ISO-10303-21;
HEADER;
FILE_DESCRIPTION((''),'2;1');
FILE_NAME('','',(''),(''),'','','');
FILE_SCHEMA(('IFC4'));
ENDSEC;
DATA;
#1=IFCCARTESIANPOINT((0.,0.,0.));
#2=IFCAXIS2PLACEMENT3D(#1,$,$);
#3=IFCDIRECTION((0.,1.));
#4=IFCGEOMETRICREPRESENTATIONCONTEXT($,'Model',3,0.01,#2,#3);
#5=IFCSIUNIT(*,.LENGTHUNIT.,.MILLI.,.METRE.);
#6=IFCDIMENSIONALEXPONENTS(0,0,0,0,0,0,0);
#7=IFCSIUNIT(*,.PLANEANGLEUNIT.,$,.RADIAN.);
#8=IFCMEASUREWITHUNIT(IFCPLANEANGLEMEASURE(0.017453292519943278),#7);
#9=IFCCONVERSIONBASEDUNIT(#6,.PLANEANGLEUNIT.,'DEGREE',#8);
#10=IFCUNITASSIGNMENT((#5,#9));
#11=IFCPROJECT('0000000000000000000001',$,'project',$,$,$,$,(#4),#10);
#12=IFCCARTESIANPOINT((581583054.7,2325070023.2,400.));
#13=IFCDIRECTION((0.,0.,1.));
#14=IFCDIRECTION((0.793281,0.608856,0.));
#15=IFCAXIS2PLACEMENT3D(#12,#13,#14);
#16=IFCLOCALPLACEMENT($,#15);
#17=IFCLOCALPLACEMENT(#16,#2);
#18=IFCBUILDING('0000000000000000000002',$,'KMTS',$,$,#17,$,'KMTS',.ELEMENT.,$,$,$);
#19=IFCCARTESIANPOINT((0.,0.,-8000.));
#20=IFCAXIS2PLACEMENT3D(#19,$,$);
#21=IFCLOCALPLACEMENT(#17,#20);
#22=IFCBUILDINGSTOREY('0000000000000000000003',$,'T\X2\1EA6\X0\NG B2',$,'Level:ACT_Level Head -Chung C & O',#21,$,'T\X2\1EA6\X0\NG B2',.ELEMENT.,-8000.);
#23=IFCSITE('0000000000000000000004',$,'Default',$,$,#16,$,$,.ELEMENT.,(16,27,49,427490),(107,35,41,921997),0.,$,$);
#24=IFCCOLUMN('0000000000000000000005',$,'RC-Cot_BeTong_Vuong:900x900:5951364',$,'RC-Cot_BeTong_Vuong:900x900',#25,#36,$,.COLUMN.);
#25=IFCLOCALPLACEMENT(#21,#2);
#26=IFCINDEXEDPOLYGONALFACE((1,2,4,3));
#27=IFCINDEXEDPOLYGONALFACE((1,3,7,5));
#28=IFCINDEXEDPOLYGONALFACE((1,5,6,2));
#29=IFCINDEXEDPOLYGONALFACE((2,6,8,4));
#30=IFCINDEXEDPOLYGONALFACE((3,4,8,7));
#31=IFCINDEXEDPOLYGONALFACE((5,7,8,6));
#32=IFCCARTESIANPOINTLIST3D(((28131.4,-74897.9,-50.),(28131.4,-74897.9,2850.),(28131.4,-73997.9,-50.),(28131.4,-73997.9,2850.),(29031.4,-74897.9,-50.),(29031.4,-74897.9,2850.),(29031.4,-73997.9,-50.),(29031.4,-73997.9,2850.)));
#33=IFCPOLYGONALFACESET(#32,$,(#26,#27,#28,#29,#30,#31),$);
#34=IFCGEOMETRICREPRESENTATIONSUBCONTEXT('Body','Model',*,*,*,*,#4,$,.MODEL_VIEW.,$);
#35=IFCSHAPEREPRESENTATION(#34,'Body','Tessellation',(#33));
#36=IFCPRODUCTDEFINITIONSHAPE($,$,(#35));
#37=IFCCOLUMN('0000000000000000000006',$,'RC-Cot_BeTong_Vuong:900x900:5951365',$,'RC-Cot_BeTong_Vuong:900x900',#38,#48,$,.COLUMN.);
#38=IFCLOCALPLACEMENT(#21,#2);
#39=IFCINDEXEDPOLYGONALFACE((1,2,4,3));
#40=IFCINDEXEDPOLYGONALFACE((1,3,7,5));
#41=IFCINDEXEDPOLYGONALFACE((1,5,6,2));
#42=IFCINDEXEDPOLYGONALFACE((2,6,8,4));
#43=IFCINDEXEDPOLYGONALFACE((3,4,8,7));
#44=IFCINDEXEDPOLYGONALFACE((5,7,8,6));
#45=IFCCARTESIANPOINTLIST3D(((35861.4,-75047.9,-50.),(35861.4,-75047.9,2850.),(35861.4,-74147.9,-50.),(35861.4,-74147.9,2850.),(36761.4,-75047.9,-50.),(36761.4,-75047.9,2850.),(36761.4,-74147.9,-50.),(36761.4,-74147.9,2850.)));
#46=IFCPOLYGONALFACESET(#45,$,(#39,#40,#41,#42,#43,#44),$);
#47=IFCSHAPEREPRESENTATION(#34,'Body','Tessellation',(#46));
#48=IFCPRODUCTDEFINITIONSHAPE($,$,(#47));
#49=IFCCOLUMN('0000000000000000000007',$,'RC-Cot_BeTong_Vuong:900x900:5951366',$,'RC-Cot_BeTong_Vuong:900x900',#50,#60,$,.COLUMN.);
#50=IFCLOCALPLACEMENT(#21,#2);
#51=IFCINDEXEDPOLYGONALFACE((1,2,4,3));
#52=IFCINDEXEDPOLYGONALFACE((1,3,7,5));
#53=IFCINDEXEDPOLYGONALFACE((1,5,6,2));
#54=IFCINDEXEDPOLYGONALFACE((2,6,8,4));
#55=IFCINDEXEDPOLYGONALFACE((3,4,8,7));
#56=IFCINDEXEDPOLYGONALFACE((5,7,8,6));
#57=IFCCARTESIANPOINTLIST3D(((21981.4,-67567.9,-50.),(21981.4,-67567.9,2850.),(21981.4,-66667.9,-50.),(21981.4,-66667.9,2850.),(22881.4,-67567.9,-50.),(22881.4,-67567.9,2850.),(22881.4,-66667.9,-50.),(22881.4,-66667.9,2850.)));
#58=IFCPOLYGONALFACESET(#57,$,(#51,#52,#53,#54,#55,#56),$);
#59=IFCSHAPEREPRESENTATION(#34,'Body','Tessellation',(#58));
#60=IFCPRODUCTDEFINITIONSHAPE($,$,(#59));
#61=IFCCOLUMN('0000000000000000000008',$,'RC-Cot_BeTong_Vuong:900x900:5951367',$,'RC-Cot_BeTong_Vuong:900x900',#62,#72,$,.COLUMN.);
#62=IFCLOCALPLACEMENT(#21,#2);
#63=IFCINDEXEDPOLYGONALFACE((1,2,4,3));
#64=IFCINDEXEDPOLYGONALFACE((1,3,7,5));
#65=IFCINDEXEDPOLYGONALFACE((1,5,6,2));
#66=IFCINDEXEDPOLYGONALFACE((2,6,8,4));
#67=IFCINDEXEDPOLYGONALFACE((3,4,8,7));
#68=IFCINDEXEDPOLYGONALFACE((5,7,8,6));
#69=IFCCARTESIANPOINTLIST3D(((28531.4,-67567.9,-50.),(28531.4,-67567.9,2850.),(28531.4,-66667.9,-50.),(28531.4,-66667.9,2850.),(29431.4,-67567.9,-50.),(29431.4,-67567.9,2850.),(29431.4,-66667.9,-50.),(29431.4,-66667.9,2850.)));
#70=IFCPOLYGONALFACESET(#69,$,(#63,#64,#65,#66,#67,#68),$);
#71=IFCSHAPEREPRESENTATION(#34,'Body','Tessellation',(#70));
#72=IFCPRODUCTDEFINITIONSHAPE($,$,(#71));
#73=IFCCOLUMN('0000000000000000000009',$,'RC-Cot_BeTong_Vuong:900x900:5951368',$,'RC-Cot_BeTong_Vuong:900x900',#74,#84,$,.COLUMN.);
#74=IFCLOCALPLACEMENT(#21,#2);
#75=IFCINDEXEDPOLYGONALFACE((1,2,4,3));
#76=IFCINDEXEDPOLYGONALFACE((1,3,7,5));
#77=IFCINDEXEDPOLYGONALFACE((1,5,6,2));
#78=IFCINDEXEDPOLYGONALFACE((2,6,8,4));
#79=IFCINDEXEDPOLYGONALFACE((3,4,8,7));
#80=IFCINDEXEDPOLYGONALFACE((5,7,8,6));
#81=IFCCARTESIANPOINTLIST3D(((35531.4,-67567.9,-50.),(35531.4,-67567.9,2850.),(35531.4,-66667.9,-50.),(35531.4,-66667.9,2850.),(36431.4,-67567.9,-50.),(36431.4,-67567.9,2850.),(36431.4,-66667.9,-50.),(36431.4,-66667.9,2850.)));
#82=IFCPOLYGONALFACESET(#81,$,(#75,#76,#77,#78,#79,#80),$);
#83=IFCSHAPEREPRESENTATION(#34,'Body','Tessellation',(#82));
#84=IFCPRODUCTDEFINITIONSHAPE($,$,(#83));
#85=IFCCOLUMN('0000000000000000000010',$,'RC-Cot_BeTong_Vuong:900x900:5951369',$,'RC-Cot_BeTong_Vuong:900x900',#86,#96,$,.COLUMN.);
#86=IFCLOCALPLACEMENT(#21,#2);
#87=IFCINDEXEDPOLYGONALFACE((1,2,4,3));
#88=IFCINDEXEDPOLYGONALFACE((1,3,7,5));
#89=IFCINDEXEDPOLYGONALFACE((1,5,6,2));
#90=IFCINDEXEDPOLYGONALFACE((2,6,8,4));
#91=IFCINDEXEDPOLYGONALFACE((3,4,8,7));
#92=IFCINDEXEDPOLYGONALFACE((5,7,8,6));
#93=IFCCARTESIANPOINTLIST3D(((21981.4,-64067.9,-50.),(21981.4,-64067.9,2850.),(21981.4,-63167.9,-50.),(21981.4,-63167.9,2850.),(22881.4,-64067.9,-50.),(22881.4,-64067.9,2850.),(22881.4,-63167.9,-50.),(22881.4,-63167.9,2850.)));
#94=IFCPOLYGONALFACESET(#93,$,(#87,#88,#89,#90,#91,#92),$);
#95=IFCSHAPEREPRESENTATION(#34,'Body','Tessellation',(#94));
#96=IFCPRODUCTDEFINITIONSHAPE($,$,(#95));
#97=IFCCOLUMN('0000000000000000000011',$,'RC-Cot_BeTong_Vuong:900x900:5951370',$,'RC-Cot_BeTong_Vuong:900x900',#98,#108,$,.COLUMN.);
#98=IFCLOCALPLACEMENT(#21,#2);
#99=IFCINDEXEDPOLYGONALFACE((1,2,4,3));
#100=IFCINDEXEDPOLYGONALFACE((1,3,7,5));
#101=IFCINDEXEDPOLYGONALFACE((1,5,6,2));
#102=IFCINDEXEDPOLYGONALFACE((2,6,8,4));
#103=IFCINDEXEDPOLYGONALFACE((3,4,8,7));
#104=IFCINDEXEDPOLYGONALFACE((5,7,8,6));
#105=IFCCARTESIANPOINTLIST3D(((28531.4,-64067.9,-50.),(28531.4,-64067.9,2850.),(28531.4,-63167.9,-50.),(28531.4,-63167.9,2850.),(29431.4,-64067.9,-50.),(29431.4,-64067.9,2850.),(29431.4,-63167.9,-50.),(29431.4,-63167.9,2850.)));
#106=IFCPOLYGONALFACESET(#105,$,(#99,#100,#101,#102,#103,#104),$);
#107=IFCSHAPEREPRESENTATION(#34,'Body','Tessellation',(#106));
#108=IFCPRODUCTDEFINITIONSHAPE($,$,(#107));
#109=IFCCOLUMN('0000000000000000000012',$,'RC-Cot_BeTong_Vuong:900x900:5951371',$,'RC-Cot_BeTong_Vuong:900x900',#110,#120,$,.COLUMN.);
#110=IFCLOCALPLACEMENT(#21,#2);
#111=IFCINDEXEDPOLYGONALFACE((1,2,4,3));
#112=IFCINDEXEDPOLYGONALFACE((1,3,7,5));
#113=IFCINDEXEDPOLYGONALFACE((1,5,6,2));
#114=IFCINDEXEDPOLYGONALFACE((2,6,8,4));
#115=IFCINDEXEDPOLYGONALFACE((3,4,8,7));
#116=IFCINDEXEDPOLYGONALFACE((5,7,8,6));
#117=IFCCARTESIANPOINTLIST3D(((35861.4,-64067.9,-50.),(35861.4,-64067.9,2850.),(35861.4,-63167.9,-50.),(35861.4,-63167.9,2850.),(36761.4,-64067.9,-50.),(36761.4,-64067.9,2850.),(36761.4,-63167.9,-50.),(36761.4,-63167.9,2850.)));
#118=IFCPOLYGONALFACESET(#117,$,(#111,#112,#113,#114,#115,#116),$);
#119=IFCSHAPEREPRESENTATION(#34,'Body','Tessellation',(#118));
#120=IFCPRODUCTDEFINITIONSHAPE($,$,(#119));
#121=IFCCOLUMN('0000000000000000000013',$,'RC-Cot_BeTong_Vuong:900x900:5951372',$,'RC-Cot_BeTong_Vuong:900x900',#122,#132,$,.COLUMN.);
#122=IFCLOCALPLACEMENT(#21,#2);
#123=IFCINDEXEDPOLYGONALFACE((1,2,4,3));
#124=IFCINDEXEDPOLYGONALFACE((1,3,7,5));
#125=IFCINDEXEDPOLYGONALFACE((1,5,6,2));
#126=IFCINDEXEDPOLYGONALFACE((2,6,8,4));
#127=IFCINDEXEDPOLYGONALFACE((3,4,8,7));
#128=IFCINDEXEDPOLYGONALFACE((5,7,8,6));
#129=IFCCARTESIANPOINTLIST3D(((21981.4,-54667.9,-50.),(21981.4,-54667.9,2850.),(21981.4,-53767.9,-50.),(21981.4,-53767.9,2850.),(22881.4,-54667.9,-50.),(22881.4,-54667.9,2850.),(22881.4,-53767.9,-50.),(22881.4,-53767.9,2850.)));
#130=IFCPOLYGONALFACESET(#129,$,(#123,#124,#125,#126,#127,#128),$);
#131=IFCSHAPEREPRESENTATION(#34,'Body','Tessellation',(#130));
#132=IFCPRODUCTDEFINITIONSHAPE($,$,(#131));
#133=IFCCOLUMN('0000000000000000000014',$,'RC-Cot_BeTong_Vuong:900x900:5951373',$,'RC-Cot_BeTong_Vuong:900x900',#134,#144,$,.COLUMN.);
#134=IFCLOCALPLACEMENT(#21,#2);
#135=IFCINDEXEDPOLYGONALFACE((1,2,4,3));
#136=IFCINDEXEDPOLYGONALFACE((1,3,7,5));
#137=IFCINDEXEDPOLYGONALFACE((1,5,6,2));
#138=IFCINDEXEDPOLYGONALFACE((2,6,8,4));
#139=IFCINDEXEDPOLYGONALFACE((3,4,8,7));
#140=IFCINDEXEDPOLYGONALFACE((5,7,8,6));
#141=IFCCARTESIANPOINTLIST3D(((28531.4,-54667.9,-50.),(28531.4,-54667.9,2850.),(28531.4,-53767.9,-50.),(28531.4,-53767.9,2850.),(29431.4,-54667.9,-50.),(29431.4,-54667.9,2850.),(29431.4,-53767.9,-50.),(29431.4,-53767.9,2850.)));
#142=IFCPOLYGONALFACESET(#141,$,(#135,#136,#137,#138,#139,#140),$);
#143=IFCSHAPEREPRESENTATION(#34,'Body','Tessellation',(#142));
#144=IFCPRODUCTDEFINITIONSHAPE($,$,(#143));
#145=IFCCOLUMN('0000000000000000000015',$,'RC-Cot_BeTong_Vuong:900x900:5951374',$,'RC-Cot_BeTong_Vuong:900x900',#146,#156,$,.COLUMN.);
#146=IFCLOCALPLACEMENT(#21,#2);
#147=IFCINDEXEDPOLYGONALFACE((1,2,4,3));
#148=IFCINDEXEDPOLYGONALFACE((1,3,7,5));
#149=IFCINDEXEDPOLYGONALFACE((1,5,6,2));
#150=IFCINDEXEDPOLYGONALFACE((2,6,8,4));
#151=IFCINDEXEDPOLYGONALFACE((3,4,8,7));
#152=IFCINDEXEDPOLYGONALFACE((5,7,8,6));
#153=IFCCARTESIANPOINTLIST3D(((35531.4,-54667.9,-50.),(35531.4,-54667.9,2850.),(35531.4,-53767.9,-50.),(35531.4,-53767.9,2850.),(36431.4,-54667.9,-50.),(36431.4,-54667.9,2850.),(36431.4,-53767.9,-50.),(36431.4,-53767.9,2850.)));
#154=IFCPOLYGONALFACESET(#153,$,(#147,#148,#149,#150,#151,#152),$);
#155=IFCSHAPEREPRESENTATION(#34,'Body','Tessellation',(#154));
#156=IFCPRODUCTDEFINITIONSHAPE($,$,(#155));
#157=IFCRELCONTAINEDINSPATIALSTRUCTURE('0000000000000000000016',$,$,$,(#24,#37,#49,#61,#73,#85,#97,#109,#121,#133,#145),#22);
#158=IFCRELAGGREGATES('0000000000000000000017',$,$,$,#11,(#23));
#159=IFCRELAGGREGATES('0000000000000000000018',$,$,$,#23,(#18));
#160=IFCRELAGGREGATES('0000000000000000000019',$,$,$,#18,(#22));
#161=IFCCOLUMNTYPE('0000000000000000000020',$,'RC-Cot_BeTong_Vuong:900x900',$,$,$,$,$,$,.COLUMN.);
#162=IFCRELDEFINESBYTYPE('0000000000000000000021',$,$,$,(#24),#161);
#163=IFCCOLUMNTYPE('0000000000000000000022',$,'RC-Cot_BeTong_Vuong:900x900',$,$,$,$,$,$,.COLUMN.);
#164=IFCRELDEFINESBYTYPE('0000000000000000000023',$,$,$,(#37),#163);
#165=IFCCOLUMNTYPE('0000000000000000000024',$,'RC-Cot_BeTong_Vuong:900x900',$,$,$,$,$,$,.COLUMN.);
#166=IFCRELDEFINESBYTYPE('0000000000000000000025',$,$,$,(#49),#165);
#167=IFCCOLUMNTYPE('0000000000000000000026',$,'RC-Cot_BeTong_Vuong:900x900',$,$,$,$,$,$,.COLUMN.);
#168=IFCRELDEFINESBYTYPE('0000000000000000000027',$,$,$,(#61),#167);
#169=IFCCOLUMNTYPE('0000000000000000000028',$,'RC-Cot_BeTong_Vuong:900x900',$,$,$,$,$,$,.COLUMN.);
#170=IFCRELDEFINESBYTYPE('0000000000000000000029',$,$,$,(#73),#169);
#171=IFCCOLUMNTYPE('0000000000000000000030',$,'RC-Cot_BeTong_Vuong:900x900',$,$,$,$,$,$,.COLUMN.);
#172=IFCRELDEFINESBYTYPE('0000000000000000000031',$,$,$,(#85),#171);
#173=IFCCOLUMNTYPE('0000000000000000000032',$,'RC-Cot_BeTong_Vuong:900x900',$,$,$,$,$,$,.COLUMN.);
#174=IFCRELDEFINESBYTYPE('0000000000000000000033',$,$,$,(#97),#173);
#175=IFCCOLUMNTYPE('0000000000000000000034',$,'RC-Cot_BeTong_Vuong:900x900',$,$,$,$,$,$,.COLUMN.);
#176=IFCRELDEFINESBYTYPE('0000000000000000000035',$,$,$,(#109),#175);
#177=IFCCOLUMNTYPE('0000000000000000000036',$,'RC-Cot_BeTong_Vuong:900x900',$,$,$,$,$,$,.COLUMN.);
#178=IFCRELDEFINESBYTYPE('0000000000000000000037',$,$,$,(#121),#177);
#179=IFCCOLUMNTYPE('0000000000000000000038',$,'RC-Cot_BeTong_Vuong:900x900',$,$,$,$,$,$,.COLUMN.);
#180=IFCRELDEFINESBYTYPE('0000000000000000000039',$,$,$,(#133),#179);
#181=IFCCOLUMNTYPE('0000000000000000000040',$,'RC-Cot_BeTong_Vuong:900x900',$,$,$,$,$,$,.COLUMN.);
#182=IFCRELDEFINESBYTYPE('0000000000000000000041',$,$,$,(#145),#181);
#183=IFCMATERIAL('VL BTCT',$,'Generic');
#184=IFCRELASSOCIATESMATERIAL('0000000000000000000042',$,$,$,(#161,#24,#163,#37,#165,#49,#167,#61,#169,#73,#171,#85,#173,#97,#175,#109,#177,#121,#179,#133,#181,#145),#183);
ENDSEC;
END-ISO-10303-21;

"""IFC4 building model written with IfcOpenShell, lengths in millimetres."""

from ifc_helpers import new_model, entity, si_unit, converted_unit, direction, frame, origin, place, context, subcontext, project, spatial, indexed_curve, outline, extrude, source, transform, mapped, material, type_object, type_shapes, element, save


model = new_model("IFC4")

# Units and contexts
model_context = context("Model", 3, precision=0.01, world=origin(), true_north=direction((0.0, 1.0)))
body_context = subcontext(model_context, "Body", "Model", "MODEL_VIEW")
ifc_project = project(units=[si_unit("LENGTHUNIT", "METRE", prefix="MILLI"), converted_unit("PLANEANGLEUNIT", "DEGREE", entity("IfcPlaneAngleMeasure", 0.017453292519943278), si_unit("PLANEANGLEUNIT", "RADIAN"), dimensions=[0, 0, 0, 0, 0, 0, 0])], contexts=[model_context])

# Site, building, storey
site_placement = place(None, frame((581583054.7, 2325070023.2, 400.0), z_axis=(0.0, 0.0, 1.0), x_axis=(0.793281, 0.608856, 0.0)))
site = spatial("IfcSite", under=ifc_project, at=site_placement, Name="Default", CompositionType="ELEMENT", RefLatitude=(16, 27, 49, 427490), RefLongitude=(107, 35, 41, 921997), RefElevation=0.0)
building_placement = place(site_placement, origin())
building = spatial("IfcBuilding", under=site, at=building_placement, Name="KMTS", LongName="KMTS", CompositionType="ELEMENT")
storey_placement = place(building_placement, frame((0.0, 0.0, -8000.0)))
storey = spatial("IfcBuildingStorey", under=building, at=storey_placement, Name="TẦNG B2", ObjectType="Level:ACT_Level Head -Chung C & O", LongName="TẦNG B2", CompositionType="ELEMENT", Elevation=-8000.0)

# Columns
ifc_material = material(Name="VL BTCT", Category="Generic")
column_type_1 = type_object("IfcColumnType", Name="RC-Cot_BeTong_Vuong:900x900", PredefinedType="COLUMN", material=ifc_material)
shared_shape_1 = source(origin(), body_context, "Body", "SweptSolid", [
    extrude(outline(indexed_curve([(-450.0, -450.0), (450.0, -450.0), (450.0, 450.0), (-450.0, 450.0), (-450.0, -450.0)], self_intersect=False)), frame((28581.4, -74447.9, -8050.0), z_axis=(0.0, 0.0, 1.0), x_axis=(-1.0, 0.0, 0.0)), (0.0, 0.0, 1.0), 2900.0),
])
type_shapes(column_type_1, [shared_shape_1])
column_1_placement = place(storey_placement, frame((0.0, 0.0, 8000.0)))
element("IfcColumn", 1, at=column_1_placement, inside=storey, type_object=column_type_1, material=ifc_material, Name="RC-Cot_BeTong_Vuong:900x900:5951364", ObjectType="RC-Cot_BeTong_Vuong:900x900", PredefinedType="COLUMN", context=body_context, shape_type="MappedRepresentation", body=[
    mapped(shared_shape_1, transform((0.0, 0.0, 0.0), scale=1.0)),
])
column_type_2 = type_object("IfcColumnType", Name="RC-Cot_BeTong_Vuong:900x900", PredefinedType="COLUMN", material=ifc_material)
shared_shape_2 = source(origin(), body_context, "Body", "SweptSolid", [
    extrude(outline(indexed_curve([(-450.0, -450.0), (450.0, -450.0), (450.0, 450.0), (-450.0, 450.0), (-450.0, -450.0)], self_intersect=False)), frame((36311.4, -74597.9, -8050.0), z_axis=(0.0, 0.0, 1.0), x_axis=(-1.0, 0.0, 0.0)), (0.0, 0.0, 1.0), 2900.0),
])
type_shapes(column_type_2, [shared_shape_2])
column_2_placement = place(storey_placement, frame((0.0, 0.0, 8000.0)))
element("IfcColumn", 2, at=column_2_placement, inside=storey, type_object=column_type_2, material=ifc_material, Name="RC-Cot_BeTong_Vuong:900x900:5951365", ObjectType="RC-Cot_BeTong_Vuong:900x900", PredefinedType="COLUMN", context=body_context, shape_type="MappedRepresentation", body=[
    mapped(shared_shape_2, transform((0.0, 0.0, 0.0), scale=1.0)),
])
column_type_3 = type_object("IfcColumnType", Name="RC-Cot_BeTong_Vuong:900x900", PredefinedType="COLUMN", material=ifc_material)
shared_shape_3 = source(origin(), body_context, "Body", "SweptSolid", [
    extrude(outline(indexed_curve([(-450.0, -450.0), (450.0, -450.0), (450.0, 450.0), (-450.0, 450.0), (-450.0, -450.0)], self_intersect=False)), frame((22431.4, -67117.9, -8050.0), z_axis=(0.0, 0.0, 1.0), x_axis=(-1.0, 0.0, 0.0)), (0.0, 0.0, 1.0), 2900.0),
])
type_shapes(column_type_3, [shared_shape_3])
column_3_placement = place(storey_placement, frame((0.0, 0.0, 8000.0)))
element("IfcColumn", 3, at=column_3_placement, inside=storey, type_object=column_type_3, material=ifc_material, Name="RC-Cot_BeTong_Vuong:900x900:5951366", ObjectType="RC-Cot_BeTong_Vuong:900x900", PredefinedType="COLUMN", context=body_context, shape_type="MappedRepresentation", body=[
    mapped(shared_shape_3, transform((0.0, 0.0, 0.0), scale=1.0)),
])
column_type_4 = type_object("IfcColumnType", Name="RC-Cot_BeTong_Vuong:900x900", PredefinedType="COLUMN", material=ifc_material)
shared_shape_4 = source(origin(), body_context, "Body", "SweptSolid", [
    extrude(outline(indexed_curve([(-450.0, -450.0), (450.0, -450.0), (450.0, 450.0), (-450.0, 450.0), (-450.0, -450.0)], self_intersect=False)), frame((28981.4, -67117.9, -8050.0), z_axis=(0.0, 0.0, 1.0), x_axis=(-1.0, 0.0, 0.0)), (0.0, 0.0, 1.0), 2900.0),
])
type_shapes(column_type_4, [shared_shape_4])
column_4_placement = place(storey_placement, frame((0.0, 0.0, 8000.0)))
element("IfcColumn", 4, at=column_4_placement, inside=storey, type_object=column_type_4, material=ifc_material, Name="RC-Cot_BeTong_Vuong:900x900:5951367", ObjectType="RC-Cot_BeTong_Vuong:900x900", PredefinedType="COLUMN", context=body_context, shape_type="MappedRepresentation", body=[
    mapped(shared_shape_4, transform((0.0, 0.0, 0.0), scale=1.0)),
])
column_type_5 = type_object("IfcColumnType", Name="RC-Cot_BeTong_Vuong:900x900", PredefinedType="COLUMN", material=ifc_material)
shared_shape_5 = source(origin(), body_context, "Body", "SweptSolid", [
    extrude(outline(indexed_curve([(-450.0, -450.0), (450.0, -450.0), (450.0, 450.0), (-450.0, 450.0), (-450.0, -450.0)], self_intersect=False)), frame((35981.4, -67117.9, -8050.0), z_axis=(0.0, 0.0, 1.0), x_axis=(-1.0, 0.0, 0.0)), (0.0, 0.0, 1.0), 2900.0),
])
type_shapes(column_type_5, [shared_shape_5])
column_5_placement = place(storey_placement, frame((0.0, 0.0, 8000.0)))
element("IfcColumn", 5, at=column_5_placement, inside=storey, type_object=column_type_5, material=ifc_material, Name="RC-Cot_BeTong_Vuong:900x900:5951368", ObjectType="RC-Cot_BeTong_Vuong:900x900", PredefinedType="COLUMN", context=body_context, shape_type="MappedRepresentation", body=[
    mapped(shared_shape_5, transform((0.0, 0.0, 0.0), scale=1.0)),
])
column_type_6 = type_object("IfcColumnType", Name="RC-Cot_BeTong_Vuong:900x900", PredefinedType="COLUMN", material=ifc_material)
shared_shape_6 = source(origin(), body_context, "Body", "SweptSolid", [
    extrude(outline(indexed_curve([(-450.0, -450.0), (450.0, -450.0), (450.0, 450.0), (-450.0, 450.0), (-450.0, -450.0)], self_intersect=False)), frame((22431.4, -63617.9, -8050.0), z_axis=(0.0, 0.0, 1.0), x_axis=(-1.0, 0.0, 0.0)), (0.0, 0.0, 1.0), 2900.0),
])
type_shapes(column_type_6, [shared_shape_6])
column_6_placement = place(storey_placement, frame((0.0, 0.0, 8000.0)))
element("IfcColumn", 6, at=column_6_placement, inside=storey, type_object=column_type_6, material=ifc_material, Name="RC-Cot_BeTong_Vuong:900x900:5951369", ObjectType="RC-Cot_BeTong_Vuong:900x900", PredefinedType="COLUMN", context=body_context, shape_type="MappedRepresentation", body=[
    mapped(shared_shape_6, transform((0.0, 0.0, 0.0), scale=1.0)),
])
column_type_7 = type_object("IfcColumnType", Name="RC-Cot_BeTong_Vuong:900x900", PredefinedType="COLUMN", material=ifc_material)
shared_shape_7 = source(origin(), body_context, "Body", "SweptSolid", [
    extrude(outline(indexed_curve([(-450.0, -450.0), (450.0, -450.0), (450.0, 450.0), (-450.0, 450.0), (-450.0, -450.0)], self_intersect=False)), frame((28981.4, -63617.9, -8050.0), z_axis=(0.0, 0.0, 1.0), x_axis=(-1.0, 0.0, 0.0)), (0.0, 0.0, 1.0), 2900.0),
])
type_shapes(column_type_7, [shared_shape_7])
column_7_placement = place(storey_placement, frame((0.0, 0.0, 8000.0)))
element("IfcColumn", 7, at=column_7_placement, inside=storey, type_object=column_type_7, material=ifc_material, Name="RC-Cot_BeTong_Vuong:900x900:5951370", ObjectType="RC-Cot_BeTong_Vuong:900x900", PredefinedType="COLUMN", context=body_context, shape_type="MappedRepresentation", body=[
    mapped(shared_shape_7, transform((0.0, 0.0, 0.0), scale=1.0)),
])
column_type_8 = type_object("IfcColumnType", Name="RC-Cot_BeTong_Vuong:900x900", PredefinedType="COLUMN", material=ifc_material)
shared_shape_8 = source(origin(), body_context, "Body", "SweptSolid", [
    extrude(outline(indexed_curve([(-450.0, -450.0), (450.0, -450.0), (450.0, 450.0), (-450.0, 450.0), (-450.0, -450.0)], self_intersect=False)), frame((36311.4, -63617.9, -8050.0), z_axis=(0.0, 0.0, 1.0), x_axis=(-1.0, 0.0, 0.0)), (0.0, 0.0, 1.0), 2900.0),
])
type_shapes(column_type_8, [shared_shape_8])
column_8_placement = place(storey_placement, frame((0.0, 0.0, 8000.0)))
element("IfcColumn", 8, at=column_8_placement, inside=storey, type_object=column_type_8, material=ifc_material, Name="RC-Cot_BeTong_Vuong:900x900:5951371", ObjectType="RC-Cot_BeTong_Vuong:900x900", PredefinedType="COLUMN", context=body_context, shape_type="MappedRepresentation", body=[
    mapped(shared_shape_8, transform((0.0, 0.0, 0.0), scale=1.0)),
])
column_type_9 = type_object("IfcColumnType", Name="RC-Cot_BeTong_Vuong:900x900", PredefinedType="COLUMN", material=ifc_material)
shared_shape_9 = source(origin(), body_context, "Body", "SweptSolid", [
    extrude(outline(indexed_curve([(-450.0, -450.0), (450.0, -450.0), (450.0, 450.0), (-450.0, 450.0), (-450.0, -450.0)], self_intersect=False)), frame((22431.4, -54217.9, -8050.0), z_axis=(0.0, 0.0, 1.0), x_axis=(-1.0, 0.0, 0.0)), (0.0, 0.0, 1.0), 2900.0),
])
type_shapes(column_type_9, [shared_shape_9])
column_9_placement = place(storey_placement, frame((0.0, 0.0, 8000.0)))
element("IfcColumn", 9, at=column_9_placement, inside=storey, type_object=column_type_9, material=ifc_material, Name="RC-Cot_BeTong_Vuong:900x900:5951372", ObjectType="RC-Cot_BeTong_Vuong:900x900", PredefinedType="COLUMN", context=body_context, shape_type="MappedRepresentation", body=[
    mapped(shared_shape_9, transform((0.0, 0.0, 0.0), scale=1.0)),
])
column_type_10 = type_object("IfcColumnType", Name="RC-Cot_BeTong_Vuong:900x900", PredefinedType="COLUMN", material=ifc_material)
shared_shape_10 = source(origin(), body_context, "Body", "SweptSolid", [
    extrude(outline(indexed_curve([(-450.0, -450.0), (450.0, -450.0), (450.0, 450.0), (-450.0, 450.0), (-450.0, -450.0)], self_intersect=False)), frame((28981.4, -54217.9, -8050.0), z_axis=(0.0, 0.0, 1.0), x_axis=(-1.0, 0.0, 0.0)), (0.0, 0.0, 1.0), 2900.0),
])
type_shapes(column_type_10, [shared_shape_10])
column_10_placement = place(storey_placement, frame((0.0, 0.0, 8000.0)))
element("IfcColumn", 10, at=column_10_placement, inside=storey, type_object=column_type_10, material=ifc_material, Name="RC-Cot_BeTong_Vuong:900x900:5951373", ObjectType="RC-Cot_BeTong_Vuong:900x900", PredefinedType="COLUMN", context=body_context, shape_type="MappedRepresentation", body=[
    mapped(shared_shape_10, transform((0.0, 0.0, 0.0), scale=1.0)),
])
column_type_11 = type_object("IfcColumnType", Name="RC-Cot_BeTong_Vuong:900x900", PredefinedType="COLUMN", material=ifc_material)
shared_shape_11 = source(origin(), body_context, "Body", "SweptSolid", [
    extrude(outline(indexed_curve([(-450.0, -450.0), (450.0, -450.0), (450.0, 450.0), (-450.0, 450.0), (-450.0, -450.0)], self_intersect=False)), frame((35981.4, -54217.9, -8050.0), z_axis=(0.0, 0.0, 1.0), x_axis=(-1.0, 0.0, 0.0)), (0.0, 0.0, 1.0), 2900.0),
])
type_shapes(column_type_11, [shared_shape_11])
column_11_placement = place(storey_placement, frame((0.0, 0.0, 8000.0)))
element("IfcColumn", 11, at=column_11_placement, inside=storey, type_object=column_type_11, material=ifc_material, Name="RC-Cot_BeTong_Vuong:900x900:5951374", ObjectType="RC-Cot_BeTong_Vuong:900x900", PredefinedType="COLUMN", context=body_context, shape_type="MappedRepresentation", body=[
    mapped(shared_shape_11, transform((0.0, 0.0, 0.0), scale=1.0)),
])

save(model, "model.ifc")
